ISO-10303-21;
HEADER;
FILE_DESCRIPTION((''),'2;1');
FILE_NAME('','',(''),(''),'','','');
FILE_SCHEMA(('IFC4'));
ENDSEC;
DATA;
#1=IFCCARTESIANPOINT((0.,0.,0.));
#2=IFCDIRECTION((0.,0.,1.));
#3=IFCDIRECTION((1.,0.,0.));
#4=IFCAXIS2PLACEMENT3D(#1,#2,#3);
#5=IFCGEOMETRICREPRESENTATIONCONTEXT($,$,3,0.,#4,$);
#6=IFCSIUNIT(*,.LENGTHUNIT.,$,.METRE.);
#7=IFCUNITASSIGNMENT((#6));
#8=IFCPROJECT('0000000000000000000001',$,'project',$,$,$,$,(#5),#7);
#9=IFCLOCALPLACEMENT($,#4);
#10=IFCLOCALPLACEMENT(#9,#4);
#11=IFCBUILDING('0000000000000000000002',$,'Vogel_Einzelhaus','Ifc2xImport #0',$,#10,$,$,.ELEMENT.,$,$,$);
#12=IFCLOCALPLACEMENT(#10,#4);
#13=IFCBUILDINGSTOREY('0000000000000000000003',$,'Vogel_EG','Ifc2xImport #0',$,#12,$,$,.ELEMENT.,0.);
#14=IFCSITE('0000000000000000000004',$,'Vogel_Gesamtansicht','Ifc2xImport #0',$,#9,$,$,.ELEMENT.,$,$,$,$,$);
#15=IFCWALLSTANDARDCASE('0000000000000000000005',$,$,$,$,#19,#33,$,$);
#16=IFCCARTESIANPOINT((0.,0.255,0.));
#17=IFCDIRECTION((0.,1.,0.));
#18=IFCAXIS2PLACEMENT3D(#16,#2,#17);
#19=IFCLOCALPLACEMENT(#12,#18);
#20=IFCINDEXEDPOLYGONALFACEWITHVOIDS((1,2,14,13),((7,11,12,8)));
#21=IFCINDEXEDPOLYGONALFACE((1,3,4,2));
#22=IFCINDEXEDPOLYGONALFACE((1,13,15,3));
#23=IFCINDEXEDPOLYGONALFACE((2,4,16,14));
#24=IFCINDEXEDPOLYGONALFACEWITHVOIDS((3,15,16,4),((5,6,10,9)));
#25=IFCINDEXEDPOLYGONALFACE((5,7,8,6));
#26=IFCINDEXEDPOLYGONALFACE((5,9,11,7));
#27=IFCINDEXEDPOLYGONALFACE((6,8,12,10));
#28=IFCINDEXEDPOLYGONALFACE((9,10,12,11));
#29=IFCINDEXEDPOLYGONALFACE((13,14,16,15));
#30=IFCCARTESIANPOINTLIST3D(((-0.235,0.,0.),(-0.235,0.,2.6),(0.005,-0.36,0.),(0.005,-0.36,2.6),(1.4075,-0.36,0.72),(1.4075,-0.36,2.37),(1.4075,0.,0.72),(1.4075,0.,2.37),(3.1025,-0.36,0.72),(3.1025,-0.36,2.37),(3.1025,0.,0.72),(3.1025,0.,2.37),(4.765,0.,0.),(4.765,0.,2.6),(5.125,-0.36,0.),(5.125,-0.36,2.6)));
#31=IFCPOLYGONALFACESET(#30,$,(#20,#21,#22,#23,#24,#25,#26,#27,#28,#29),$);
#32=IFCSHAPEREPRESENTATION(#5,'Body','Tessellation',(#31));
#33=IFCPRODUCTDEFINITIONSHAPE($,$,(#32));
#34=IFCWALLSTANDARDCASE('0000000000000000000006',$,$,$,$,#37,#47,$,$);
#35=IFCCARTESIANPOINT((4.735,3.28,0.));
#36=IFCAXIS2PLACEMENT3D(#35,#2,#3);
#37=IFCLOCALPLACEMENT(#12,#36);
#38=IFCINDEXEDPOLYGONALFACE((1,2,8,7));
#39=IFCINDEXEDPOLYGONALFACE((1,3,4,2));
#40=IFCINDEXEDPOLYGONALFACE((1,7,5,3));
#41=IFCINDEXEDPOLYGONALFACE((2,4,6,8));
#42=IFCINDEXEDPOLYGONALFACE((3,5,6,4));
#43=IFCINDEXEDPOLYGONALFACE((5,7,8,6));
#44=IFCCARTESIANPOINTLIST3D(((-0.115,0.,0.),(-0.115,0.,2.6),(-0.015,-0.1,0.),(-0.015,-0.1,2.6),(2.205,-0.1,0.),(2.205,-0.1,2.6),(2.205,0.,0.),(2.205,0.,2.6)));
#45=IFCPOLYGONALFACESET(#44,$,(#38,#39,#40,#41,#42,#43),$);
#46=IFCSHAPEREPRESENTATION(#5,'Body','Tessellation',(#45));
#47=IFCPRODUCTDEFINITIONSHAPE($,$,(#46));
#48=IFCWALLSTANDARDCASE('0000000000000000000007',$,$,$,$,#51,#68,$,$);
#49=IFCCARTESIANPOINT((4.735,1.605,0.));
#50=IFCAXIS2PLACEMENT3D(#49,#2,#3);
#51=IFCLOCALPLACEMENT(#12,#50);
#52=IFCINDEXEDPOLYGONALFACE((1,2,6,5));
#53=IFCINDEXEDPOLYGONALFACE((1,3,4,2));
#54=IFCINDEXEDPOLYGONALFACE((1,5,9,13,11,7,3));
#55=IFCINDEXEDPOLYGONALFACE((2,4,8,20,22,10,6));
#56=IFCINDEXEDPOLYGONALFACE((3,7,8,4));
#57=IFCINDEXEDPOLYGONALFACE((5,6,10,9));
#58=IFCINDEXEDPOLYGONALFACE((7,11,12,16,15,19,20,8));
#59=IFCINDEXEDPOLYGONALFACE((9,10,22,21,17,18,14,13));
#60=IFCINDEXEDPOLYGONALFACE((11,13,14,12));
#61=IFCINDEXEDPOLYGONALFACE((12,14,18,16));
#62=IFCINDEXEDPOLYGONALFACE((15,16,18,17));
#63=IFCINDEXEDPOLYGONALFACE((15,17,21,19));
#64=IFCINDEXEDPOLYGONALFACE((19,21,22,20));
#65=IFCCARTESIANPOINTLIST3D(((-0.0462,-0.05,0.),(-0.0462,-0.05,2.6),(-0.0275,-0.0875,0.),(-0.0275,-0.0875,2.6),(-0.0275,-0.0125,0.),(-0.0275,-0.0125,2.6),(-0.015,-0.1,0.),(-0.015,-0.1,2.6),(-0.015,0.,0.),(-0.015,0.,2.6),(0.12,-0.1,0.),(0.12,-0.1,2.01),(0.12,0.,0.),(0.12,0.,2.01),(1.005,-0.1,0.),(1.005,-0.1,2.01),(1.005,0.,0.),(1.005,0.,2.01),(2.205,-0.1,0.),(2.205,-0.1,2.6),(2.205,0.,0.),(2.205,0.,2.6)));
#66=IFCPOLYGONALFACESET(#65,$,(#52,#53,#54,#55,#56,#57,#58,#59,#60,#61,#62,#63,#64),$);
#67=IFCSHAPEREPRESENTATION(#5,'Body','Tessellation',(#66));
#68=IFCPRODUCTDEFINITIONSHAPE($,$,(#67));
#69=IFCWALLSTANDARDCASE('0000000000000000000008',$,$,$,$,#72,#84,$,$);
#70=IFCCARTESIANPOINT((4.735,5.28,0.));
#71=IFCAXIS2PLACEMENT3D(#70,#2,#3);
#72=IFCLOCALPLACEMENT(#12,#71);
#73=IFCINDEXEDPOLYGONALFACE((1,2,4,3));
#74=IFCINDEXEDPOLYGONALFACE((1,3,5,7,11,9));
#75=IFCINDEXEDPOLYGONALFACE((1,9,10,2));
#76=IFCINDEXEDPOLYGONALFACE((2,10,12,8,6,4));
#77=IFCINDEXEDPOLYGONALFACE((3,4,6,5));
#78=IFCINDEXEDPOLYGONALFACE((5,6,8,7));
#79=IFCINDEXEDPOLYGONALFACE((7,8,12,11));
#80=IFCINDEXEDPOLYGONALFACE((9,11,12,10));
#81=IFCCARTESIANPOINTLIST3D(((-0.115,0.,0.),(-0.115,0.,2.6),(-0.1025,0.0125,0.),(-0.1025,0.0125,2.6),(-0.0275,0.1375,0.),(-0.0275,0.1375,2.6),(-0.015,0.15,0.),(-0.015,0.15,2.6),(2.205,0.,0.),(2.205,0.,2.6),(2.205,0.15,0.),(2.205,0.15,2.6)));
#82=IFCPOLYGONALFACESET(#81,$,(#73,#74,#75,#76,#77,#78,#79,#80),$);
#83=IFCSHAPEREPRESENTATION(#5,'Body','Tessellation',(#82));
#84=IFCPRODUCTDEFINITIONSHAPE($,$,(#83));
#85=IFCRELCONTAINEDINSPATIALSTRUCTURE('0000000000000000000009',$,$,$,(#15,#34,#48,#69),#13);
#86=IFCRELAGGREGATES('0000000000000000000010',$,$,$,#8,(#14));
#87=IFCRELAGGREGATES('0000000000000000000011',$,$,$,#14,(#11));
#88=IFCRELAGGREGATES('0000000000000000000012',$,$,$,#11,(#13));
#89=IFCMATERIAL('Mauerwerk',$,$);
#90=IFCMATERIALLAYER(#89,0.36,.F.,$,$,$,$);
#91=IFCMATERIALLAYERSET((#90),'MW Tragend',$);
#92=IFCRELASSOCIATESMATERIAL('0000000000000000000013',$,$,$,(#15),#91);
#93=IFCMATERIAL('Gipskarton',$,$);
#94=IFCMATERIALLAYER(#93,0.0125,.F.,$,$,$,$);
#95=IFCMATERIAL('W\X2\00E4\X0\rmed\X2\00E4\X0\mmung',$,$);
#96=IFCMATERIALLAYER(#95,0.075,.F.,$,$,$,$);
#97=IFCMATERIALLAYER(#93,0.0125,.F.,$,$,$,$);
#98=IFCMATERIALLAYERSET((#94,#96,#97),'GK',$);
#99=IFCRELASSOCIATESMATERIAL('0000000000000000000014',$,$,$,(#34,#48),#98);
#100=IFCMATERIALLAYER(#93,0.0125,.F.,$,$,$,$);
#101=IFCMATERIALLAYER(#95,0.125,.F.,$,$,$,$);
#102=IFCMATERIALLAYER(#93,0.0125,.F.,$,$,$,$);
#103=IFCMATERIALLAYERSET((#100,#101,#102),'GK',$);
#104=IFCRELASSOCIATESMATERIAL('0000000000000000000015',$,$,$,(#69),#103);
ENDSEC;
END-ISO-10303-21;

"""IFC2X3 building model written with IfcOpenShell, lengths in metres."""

from ifc_helpers import new_model, si_unit, frame, origin_with_axes, origin_2d_with_axis, place, context, project, spatial, polyline, rectangle, outline, extrude, shape, material, layer, layer_set, layer_usage, element, save


model = new_model("IFC2X3")

# Units and contexts
context_of_model = context(None, 3, precision=0.0, world=origin_with_axes())
ifc_project = project(units=[si_unit("LENGTHUNIT", "METRE")], contexts=[context_of_model])

# Site, building, storey
site_placement = place(None, origin_with_axes())
site = spatial("IfcSite", under=ifc_project, at=site_placement, Name="Vogel_Gesamtansicht", Description="Ifc2xImport #0", CompositionType="ELEMENT")
building_placement = place(site_placement, origin_with_axes())
building = spatial("IfcBuilding", under=site, at=building_placement, Name="Vogel_Einzelhaus", Description="Ifc2xImport #0", CompositionType="ELEMENT")
storey_placement = place(building_placement, origin_with_axes())
storey = spatial("IfcBuildingStorey", under=building, at=storey_placement, Name="Vogel_EG", Description="Ifc2xImport #0", CompositionType="ELEMENT", Elevation=0.0)

# Shared definitions
ifc_material_1 = material(Name="Mauerwerk")

# Shared definitions
ifc_layer_1 = layer(ifc_material_1, 0.36, ventilated=False)
ifc_layer_set_1 = layer_set([ifc_layer_1], Name="MW Tragend")
ifc_layer_usage_1 = layer_usage(ifc_layer_set_1, "AXIS2", "POSITIVE", -0.36)

# Wall, opening
wall_1_placement = place(storey_placement, frame((0.0, 0.255, 0.0), z_axis=(0.0, 0.0, 1.0), x_axis=(0.0, 1.0, 0.0)))
wall_1 = element("IfcWallStandardCase", 1, at=wall_1_placement, inside=storey, material=ifc_layer_usage_1, context=context_of_model, shape_type="SweptSolid", body=[
    extrude(outline(polyline([(0.6125, 0.0), (-0.235, 0.0), (0.005, -0.36), (0.555, -0.36), (0.6125, -0.36), (0.67, -0.36), (5.125, -0.36), (4.765, 0.0), (0.6125, 0.0)])), origin_with_axes(), (0.0, 0.0, 1.0), 2.6),
])
opening_1_placement = place(wall_1_placement, frame((1.4075, 0.0, 0.72), z_axis=(1.0, 0.0, 0.0), x_axis=(0.0, 0.0, 1.0)))
element("IfcOpeningElement", 2, at=opening_1_placement, cuts=wall_1, shapes=[
    shape(context_of_model, None, "SweptSolid", [extrude(rectangle(XDim=1.65, YDim=1.695, at=origin_2d_with_axis()), frame((0.825, 0.0, 0.8475), z_axis=(0.0, 1.0, 0.0), x_axis=(1.0, 0.0, 0.0)), (0.0, 0.0, 1.0), 0.36)]),
])

# Wall
ifc_material_2 = material(Name="Gipskarton")
ifc_layer_2 = layer(ifc_material_2, 0.0125, ventilated=False)
ifc_material_3 = material(Name="Wärmedämmung")
ifc_layer_3 = layer(ifc_material_3, 0.075, ventilated=False)
ifc_layer_4 = layer(ifc_material_2, 0.0125, ventilated=False)
ifc_layer_set_2 = layer_set([ifc_layer_2, ifc_layer_3, ifc_layer_4], Name="GK")
ifc_layer_usage_2 = layer_usage(ifc_layer_set_2, "AXIS2", "POSITIVE", -0.1)
wall_2_placement = place(storey_placement, frame((4.735, 3.28, 0.0), z_axis=(0.0, 0.0, 1.0), x_axis=(1.0, 0.0, 0.0)))
element("IfcWallStandardCase", 3, at=wall_2_placement, inside=storey, material=ifc_layer_usage_2, context=context_of_model, shape_type="SweptSolid", body=[
    extrude(outline(polyline([(-0.015, -0.1), (2.205, -0.1), (2.205, 0.0), (-0.115, 0.0), (-0.015, -0.1)])), origin_with_axes(), (0.0, 0.0, 1.0), 2.6),
])

# Wall, opening
wall_3_placement = place(storey_placement, frame((4.735, 1.605, 0.0), z_axis=(0.0, 0.0, 1.0), x_axis=(1.0, 0.0, 0.0)))
wall_3 = element("IfcWallStandardCase", 4, at=wall_3_placement, inside=storey, material=ifc_layer_usage_2, context=context_of_model, shape_type="SweptSolid", body=[
    extrude(outline(polyline([(-0.0275, -0.0875), (-0.015, -0.1), (2.205, -0.1), (2.205, 0.0), (-0.015, 0.0), (-0.0275, -0.0125), (-0.0462, -0.05), (-0.0275, -0.0875)])), origin_with_axes(), (0.0, 0.0, 1.0), 2.6),
])
opening_2_placement = place(wall_3_placement, frame((0.12, 0.0, 0.0), z_axis=(1.0, 0.0, 0.0), x_axis=(0.0, 0.0, 1.0)))
element("IfcOpeningElement", 5, at=opening_2_placement, cuts=wall_3, shapes=[
    shape(context_of_model, None, "SweptSolid", [extrude(rectangle(XDim=2.01, YDim=0.885, at=origin_2d_with_axis()), frame((1.005, 0.0, 0.4425), z_axis=(0.0, 1.0, 0.0), x_axis=(1.0, 0.0, 0.0)), (0.0, 0.0, 1.0), 0.1)]),
])

# Wall
ifc_layer_5 = layer(ifc_material_2, 0.0125, ventilated=False)
ifc_layer_6 = layer(ifc_material_3, 0.125, ventilated=False)
ifc_layer_7 = layer(ifc_material_2, 0.0125, ventilated=False)
ifc_layer_set_3 = layer_set([ifc_layer_5, ifc_layer_6, ifc_layer_7], Name="GK")
ifc_layer_usage_3 = layer_usage(ifc_layer_set_3, "AXIS2", "POSITIVE", 0.0)
wall_4_placement = place(storey_placement, frame((4.735, 5.28, 0.0), z_axis=(0.0, 0.0, 1.0), x_axis=(1.0, 0.0, 0.0)))
element("IfcWallStandardCase", 6, at=wall_4_placement, inside=storey, material=ifc_layer_usage_3, context=context_of_model, shape_type="SweptSolid", body=[
    extrude(outline(polyline([(-0.1025, 0.0125), (-0.115, 0.0), (2.205, 0.0), (2.205, 0.15), (-0.015, 0.15), (-0.0275, 0.1375), (-0.1025, 0.0125)])), origin_with_axes(), (0.0, 0.0, 1.0), 2.6),
])

save(model, "model.ifc")
